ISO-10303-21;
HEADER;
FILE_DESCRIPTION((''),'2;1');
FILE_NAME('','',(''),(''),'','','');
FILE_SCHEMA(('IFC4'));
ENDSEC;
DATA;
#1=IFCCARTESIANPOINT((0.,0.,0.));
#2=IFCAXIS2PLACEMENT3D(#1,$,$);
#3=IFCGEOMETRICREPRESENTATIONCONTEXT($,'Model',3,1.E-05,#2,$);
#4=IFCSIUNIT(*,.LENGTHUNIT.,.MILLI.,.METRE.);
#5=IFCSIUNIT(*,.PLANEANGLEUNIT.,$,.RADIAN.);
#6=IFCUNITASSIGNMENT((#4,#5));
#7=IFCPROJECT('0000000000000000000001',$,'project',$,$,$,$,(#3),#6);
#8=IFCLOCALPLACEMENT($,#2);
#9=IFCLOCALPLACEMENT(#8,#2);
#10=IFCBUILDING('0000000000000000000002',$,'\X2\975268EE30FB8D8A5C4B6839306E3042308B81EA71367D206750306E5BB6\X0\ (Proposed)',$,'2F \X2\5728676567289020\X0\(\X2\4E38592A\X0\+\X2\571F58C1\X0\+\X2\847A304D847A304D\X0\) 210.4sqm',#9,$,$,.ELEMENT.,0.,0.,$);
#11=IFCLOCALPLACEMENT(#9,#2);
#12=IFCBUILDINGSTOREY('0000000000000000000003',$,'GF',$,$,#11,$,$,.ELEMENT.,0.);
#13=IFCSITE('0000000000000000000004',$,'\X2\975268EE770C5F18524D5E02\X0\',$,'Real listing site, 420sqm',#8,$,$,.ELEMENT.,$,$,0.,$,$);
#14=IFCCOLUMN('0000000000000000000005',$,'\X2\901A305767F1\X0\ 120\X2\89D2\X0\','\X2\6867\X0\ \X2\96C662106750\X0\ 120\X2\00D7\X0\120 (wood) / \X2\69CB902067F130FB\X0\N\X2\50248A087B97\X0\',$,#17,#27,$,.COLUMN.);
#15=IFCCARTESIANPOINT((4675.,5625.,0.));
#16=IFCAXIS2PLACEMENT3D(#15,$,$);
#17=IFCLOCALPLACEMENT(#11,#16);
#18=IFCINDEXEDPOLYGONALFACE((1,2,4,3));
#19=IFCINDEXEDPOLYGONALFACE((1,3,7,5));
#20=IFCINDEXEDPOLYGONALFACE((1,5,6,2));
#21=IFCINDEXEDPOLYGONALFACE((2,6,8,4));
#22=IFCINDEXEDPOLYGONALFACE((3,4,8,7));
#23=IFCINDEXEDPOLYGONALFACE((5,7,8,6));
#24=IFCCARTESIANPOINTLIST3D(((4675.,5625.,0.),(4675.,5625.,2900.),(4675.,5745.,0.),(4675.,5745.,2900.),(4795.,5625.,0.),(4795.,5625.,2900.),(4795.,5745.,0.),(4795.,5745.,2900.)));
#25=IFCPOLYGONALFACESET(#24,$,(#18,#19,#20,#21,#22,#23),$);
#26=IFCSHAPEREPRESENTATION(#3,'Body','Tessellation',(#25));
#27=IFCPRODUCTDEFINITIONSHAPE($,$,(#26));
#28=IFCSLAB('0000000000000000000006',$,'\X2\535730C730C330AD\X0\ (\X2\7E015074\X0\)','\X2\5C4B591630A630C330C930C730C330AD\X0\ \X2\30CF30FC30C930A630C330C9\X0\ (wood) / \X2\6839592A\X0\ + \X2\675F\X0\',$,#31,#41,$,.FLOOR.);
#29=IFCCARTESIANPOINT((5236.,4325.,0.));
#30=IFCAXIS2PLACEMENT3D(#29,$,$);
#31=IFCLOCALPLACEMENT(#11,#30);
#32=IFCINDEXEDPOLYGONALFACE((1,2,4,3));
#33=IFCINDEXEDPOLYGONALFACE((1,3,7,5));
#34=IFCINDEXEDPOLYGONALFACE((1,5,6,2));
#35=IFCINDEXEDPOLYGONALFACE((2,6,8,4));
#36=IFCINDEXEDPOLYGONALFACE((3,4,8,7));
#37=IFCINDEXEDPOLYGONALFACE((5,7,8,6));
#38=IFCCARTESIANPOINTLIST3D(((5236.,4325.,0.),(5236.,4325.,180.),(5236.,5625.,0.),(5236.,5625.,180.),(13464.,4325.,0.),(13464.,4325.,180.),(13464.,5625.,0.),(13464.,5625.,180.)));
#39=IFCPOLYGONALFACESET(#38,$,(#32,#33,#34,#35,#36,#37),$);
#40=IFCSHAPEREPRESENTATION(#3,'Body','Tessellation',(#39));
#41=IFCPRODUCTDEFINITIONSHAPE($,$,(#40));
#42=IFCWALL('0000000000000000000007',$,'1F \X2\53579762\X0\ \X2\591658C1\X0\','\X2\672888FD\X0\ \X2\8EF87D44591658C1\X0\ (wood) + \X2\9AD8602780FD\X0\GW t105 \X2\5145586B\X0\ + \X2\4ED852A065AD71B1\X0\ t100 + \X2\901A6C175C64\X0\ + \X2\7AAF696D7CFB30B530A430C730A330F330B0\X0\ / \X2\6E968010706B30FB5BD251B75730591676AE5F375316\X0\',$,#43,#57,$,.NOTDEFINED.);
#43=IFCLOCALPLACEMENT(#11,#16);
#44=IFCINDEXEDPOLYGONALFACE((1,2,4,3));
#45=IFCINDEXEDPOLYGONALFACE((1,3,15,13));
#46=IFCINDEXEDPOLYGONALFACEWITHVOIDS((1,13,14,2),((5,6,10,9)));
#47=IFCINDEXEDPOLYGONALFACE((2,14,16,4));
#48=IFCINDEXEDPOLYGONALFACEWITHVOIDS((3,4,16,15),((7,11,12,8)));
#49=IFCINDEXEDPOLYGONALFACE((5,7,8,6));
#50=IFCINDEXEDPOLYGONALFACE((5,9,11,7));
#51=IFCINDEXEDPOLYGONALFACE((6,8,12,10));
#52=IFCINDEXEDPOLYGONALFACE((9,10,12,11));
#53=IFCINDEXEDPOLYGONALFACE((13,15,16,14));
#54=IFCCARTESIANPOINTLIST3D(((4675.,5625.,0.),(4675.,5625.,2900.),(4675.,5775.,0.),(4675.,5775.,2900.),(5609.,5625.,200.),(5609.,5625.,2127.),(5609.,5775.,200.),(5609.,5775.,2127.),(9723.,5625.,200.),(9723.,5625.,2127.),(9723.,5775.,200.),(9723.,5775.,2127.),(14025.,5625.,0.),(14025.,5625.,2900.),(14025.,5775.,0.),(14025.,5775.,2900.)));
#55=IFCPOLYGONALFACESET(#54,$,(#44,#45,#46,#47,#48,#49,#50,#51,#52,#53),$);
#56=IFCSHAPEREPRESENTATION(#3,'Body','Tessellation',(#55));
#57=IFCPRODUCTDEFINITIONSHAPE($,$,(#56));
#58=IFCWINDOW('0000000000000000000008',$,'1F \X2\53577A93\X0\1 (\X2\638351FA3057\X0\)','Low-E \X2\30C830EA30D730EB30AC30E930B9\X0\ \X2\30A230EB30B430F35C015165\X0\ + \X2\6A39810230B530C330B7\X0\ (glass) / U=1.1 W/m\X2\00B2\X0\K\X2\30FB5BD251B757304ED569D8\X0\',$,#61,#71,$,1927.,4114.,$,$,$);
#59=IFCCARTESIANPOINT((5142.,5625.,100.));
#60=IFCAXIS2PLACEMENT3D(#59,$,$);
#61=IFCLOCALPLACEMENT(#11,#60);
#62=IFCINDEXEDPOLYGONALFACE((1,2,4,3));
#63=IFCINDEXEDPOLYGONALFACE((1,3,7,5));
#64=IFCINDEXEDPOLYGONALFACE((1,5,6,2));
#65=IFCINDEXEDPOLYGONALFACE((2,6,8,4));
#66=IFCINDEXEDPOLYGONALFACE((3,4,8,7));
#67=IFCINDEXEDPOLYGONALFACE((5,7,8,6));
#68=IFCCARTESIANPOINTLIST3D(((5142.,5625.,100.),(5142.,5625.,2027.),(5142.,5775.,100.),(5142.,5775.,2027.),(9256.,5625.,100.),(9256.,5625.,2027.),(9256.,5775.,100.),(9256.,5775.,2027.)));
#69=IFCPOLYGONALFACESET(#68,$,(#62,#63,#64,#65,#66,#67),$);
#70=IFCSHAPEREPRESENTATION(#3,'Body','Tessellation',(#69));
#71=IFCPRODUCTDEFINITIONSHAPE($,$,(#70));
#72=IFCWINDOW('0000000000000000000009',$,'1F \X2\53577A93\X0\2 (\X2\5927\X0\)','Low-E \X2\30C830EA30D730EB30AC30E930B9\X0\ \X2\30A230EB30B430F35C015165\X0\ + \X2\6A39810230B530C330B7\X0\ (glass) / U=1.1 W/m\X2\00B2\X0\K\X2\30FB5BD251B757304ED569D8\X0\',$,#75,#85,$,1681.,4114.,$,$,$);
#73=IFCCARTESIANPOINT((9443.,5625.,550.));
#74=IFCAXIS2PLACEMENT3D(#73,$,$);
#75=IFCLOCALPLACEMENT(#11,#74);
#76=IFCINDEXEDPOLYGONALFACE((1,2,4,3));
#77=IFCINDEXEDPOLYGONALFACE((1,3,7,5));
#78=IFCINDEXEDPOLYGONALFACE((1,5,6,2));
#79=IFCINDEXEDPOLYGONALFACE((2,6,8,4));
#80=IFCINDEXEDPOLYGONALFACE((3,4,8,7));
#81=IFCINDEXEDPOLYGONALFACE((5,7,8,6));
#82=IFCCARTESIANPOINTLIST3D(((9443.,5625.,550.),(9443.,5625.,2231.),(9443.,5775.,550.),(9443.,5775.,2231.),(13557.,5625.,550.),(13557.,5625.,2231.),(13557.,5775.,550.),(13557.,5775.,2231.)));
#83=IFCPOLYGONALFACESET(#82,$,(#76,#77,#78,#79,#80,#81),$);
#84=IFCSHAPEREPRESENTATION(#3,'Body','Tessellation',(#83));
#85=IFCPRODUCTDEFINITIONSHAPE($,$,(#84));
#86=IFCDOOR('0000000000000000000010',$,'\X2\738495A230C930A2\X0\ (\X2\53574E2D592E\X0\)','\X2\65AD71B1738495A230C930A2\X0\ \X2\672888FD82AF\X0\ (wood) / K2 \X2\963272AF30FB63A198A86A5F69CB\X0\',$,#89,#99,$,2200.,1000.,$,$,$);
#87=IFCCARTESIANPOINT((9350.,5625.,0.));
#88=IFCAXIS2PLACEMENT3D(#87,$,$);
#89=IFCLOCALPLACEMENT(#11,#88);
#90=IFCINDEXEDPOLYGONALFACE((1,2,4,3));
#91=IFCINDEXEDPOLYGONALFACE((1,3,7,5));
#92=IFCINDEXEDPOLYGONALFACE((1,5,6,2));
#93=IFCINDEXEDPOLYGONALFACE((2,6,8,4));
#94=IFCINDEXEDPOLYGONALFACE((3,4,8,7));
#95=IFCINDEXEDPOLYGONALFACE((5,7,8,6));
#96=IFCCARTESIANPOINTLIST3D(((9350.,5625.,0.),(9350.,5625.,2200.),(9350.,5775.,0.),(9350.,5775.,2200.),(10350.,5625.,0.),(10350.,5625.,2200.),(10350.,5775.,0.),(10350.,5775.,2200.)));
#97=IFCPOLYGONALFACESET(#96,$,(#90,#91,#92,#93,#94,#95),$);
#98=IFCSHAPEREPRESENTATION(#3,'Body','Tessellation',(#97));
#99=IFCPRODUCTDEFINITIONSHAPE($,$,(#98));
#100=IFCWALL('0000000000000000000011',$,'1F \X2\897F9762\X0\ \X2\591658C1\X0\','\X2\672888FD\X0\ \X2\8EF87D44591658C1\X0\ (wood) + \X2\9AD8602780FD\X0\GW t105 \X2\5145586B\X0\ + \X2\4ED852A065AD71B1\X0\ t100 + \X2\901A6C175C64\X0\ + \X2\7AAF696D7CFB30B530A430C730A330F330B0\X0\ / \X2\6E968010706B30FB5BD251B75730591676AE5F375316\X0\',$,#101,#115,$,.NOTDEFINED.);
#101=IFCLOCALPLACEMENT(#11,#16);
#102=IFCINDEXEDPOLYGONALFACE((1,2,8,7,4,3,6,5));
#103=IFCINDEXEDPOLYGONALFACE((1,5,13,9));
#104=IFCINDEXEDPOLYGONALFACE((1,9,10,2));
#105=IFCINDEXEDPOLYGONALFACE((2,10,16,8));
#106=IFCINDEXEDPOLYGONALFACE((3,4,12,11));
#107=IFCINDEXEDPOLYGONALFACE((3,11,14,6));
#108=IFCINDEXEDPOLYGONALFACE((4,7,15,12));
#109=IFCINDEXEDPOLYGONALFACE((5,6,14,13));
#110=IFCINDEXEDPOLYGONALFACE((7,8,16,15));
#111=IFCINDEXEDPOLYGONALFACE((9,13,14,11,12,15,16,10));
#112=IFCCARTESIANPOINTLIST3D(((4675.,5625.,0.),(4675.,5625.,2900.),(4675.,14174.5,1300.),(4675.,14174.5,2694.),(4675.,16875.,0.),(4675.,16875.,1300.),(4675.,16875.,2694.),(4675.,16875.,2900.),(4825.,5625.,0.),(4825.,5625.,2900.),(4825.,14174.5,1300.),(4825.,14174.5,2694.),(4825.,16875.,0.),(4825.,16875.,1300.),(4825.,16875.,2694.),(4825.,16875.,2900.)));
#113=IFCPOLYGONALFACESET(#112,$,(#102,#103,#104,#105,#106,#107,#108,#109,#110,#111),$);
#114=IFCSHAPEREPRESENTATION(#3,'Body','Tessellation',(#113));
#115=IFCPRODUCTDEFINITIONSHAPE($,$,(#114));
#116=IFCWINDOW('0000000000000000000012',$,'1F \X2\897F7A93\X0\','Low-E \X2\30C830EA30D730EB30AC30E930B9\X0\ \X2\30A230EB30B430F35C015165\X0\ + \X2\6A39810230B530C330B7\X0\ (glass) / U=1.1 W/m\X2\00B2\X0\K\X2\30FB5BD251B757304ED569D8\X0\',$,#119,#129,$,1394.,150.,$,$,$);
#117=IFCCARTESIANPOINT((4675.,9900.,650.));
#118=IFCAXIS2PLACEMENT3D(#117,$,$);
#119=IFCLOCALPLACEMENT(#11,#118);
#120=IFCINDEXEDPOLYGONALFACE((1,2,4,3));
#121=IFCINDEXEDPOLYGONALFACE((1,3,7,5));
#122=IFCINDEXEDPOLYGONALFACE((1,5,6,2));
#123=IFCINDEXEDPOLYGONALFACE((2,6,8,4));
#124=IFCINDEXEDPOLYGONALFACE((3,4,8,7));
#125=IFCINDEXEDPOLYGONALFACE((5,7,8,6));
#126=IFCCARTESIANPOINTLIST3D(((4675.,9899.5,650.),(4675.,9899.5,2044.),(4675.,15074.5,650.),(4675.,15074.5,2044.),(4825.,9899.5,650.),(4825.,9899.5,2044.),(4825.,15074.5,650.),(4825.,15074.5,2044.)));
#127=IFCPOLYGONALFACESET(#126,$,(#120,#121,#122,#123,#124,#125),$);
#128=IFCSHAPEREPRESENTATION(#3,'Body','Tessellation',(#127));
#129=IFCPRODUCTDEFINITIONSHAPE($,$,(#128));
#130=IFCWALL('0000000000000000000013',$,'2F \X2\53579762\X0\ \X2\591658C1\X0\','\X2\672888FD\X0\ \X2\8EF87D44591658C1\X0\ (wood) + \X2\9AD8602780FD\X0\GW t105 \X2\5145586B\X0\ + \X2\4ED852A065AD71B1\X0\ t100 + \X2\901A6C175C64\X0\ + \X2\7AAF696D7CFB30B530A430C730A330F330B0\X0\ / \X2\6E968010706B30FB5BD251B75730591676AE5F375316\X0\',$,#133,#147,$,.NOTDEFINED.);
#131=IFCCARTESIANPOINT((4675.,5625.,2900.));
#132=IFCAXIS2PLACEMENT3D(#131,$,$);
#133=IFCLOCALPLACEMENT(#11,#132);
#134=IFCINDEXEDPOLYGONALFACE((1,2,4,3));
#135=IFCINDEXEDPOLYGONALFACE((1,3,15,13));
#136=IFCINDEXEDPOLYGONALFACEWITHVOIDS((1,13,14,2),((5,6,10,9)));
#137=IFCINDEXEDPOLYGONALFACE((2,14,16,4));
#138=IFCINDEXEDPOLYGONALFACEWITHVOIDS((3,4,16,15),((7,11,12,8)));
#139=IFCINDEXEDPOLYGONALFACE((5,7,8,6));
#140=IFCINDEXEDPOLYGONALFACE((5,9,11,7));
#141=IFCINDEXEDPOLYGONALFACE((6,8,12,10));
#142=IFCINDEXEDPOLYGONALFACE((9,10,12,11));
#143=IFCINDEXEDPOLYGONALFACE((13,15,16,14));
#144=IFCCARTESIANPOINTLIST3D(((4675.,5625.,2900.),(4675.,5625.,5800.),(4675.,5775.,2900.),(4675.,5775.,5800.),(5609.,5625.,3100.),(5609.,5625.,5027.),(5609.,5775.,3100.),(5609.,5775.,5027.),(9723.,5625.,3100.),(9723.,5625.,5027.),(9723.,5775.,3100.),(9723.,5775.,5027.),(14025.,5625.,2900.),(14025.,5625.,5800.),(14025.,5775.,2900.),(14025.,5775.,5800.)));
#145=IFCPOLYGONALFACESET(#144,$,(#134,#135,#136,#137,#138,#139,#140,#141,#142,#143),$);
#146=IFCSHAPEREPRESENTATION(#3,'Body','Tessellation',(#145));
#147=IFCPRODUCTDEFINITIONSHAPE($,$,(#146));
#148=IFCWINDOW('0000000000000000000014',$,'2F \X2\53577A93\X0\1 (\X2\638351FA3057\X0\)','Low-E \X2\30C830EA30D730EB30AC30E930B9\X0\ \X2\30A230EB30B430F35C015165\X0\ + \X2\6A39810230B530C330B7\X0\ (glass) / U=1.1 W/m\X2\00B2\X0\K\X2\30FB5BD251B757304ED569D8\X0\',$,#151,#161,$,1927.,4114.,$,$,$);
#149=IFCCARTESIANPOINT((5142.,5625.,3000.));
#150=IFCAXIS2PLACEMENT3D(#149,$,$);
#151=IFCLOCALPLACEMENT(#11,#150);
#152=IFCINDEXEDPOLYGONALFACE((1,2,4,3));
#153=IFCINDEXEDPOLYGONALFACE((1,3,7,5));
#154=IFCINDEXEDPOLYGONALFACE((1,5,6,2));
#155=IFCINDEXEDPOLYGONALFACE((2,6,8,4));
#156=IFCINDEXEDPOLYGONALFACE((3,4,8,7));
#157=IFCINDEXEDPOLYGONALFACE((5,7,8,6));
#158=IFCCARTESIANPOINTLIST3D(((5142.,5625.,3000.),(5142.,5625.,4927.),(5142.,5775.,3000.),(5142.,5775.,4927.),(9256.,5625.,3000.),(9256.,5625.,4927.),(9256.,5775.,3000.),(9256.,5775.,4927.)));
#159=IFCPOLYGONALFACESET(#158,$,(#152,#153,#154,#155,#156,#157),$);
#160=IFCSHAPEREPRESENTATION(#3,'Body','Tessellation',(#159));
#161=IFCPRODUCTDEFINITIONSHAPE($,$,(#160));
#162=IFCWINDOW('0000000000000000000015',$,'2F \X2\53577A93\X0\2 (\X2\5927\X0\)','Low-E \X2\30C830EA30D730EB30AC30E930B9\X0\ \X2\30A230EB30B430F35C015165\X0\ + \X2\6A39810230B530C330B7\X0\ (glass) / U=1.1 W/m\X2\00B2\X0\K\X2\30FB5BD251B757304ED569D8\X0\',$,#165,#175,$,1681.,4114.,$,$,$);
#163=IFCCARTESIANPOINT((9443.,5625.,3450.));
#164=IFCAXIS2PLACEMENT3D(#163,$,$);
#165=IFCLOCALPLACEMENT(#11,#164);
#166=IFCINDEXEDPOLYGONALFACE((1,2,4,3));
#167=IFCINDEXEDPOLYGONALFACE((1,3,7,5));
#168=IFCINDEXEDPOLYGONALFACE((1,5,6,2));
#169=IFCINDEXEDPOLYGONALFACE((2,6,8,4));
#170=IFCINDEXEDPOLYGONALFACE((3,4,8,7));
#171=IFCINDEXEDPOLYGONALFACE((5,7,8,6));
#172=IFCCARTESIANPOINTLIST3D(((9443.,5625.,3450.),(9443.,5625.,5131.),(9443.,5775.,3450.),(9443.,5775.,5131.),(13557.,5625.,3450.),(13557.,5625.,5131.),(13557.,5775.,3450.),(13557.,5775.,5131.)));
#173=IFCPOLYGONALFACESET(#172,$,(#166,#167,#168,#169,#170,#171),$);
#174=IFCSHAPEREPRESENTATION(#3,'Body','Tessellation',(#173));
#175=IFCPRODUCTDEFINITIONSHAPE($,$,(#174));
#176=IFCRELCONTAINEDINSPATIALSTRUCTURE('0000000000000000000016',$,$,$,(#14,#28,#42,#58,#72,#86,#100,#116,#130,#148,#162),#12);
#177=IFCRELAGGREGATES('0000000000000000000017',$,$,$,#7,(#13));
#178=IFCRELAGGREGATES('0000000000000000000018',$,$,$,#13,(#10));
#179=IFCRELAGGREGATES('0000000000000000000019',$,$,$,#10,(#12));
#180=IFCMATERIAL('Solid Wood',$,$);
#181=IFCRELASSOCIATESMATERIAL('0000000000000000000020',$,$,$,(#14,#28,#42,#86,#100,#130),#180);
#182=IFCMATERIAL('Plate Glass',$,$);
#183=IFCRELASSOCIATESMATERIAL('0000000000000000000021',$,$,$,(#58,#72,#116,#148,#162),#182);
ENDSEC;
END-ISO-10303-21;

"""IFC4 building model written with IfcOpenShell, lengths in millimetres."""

from ifc_helpers import new_model, si_unit, frame, frame_2d, origin, place, context, project, spatial, rectangle, extrude, material, element, fill, save


model = new_model("IFC4")

# Units and contexts
model_context = context("Model", 3, precision=1e-05, world=origin())
ifc_project = project(units=[si_unit("LENGTHUNIT", "METRE", prefix="MILLI"), si_unit("PLANEANGLEUNIT", "RADIAN")], contexts=[model_context])

# Site, building, storey
site_placement = place(None, origin())
site = spatial("IfcSite", under=ifc_project, at=site_placement, Name="青森県弘前市", ObjectType="Real listing site, 420sqm", CompositionType="ELEMENT", RefElevation=0.0)
building_placement = place(site_placement, origin())
building = spatial("IfcBuilding", under=site, at=building_placement, Name="青森・越屋根のある自然素材の家 (Proposed)", ObjectType="2F 在来木造(丸太+土壁+葺き葺き) 210.4sqm", CompositionType="ELEMENT", ElevationOfRefHeight=0.0, ElevationOfTerrain=0.0)
storey_placement = place(building_placement, origin())
storey = spatial("IfcBuildingStorey", under=building, at=storey_placement, Name="GF", CompositionType="ELEMENT", Elevation=0.0)

# Column
ifc_material_1 = material(Name="Solid Wood")
column_placement = place(storey_placement, frame((4675.0, 5625.0, 0.0)))
element("IfcColumn", 1, at=column_placement, inside=storey, material=ifc_material_1, Name="通し柱 120角", Description="桧 集成材 120×120 (wood) / 構造柱・N値計算", PredefinedType="COLUMN", context=model_context, shape_type="SweptSolid", body=[
    extrude(rectangle(XDim=120.0, YDim=120.0, at=frame_2d((60.0, 60.0))), frame((4675.0, 5625.0, 0.0)), (0.0, 0.0, 1.0), 2900.0),
])

# Slab
slab_1_placement = place(storey_placement, frame((5236.0, 4325.0, 0.0)))
element("IfcSlab", 2, at=slab_1_placement, inside=storey, material=ifc_material_1, Name="南デッキ (縁側)", Description="屋外ウッドデッキ ハードウッド (wood) / 根太 + 束", PredefinedType="FLOOR", context=model_context, shape_type="SweptSolid", body=[
    extrude(rectangle(XDim=8228.0, YDim=1300.0, at=frame_2d((4114.0, 650.0))), frame((5236.0, 4325.0, 0.0)), (0.0, 0.0, 1.0), 180.0),
])

# Wall, openings, windows, door
wall_1_placement = place(storey_placement, frame((4675.0, 5625.0, 0.0)))
wall_1 = element("IfcWall", 3, at=wall_1_placement, inside=storey, material=ifc_material_1, Name="1F 南面 外壁", Description="木製 軸組外壁 (wood) + 高性能GW t105 充填 + 付加断熱 t100 + 通気層 + 窯業系サイディング / 準耐火・寒冷地外皮強化", PredefinedType="NOTDEFINED", context=model_context, shape_type="SweptSolid", body=[
    extrude(rectangle(XDim=9350.0, YDim=150.0, at=frame_2d((4675.0, 75.0))), frame((4675.0, 5625.0, 0.0)), (0.0, 0.0, 1.0), 2900.0),
])
opening_1_placement = place(storey_placement, frame((5142.0, 5625.0, 100.0)))
opening_1 = element("IfcOpeningElement", 4, at=opening_1_placement, cuts=wall_1, PredefinedType="NOTDEFINED", context=model_context, shape_type="SweptSolid", body=[
    extrude(rectangle(XDim=4114.0, YDim=150.0, at=frame_2d((2057.0, 75.0))), frame((5142.0, 5625.0, 100.0)), (0.0, 0.0, 1.0), 1927.0),
])
opening_2_placement = place(storey_placement, frame((9443.0, 5625.0, 550.0)))
opening_2 = element("IfcOpeningElement", 5, at=opening_2_placement, cuts=wall_1, PredefinedType="NOTDEFINED", context=model_context, shape_type="SweptSolid", body=[
    extrude(rectangle(XDim=4114.0, YDim=150.0, at=frame_2d((2057.0, 75.0))), frame((9443.0, 5625.0, 550.0)), (0.0, 0.0, 1.0), 1681.0),
])
opening_3_placement = place(storey_placement, frame((9350.0, 5625.0, 0.0)))
opening_3 = element("IfcOpeningElement", 6, at=opening_3_placement, cuts=wall_1, PredefinedType="NOTDEFINED", context=model_context, shape_type="SweptSolid", body=[
    extrude(rectangle(XDim=1000.0, YDim=150.0, at=frame_2d((500.0, 75.0))), frame((9350.0, 5625.0, 0.0)), (0.0, 0.0, 1.0), 2200.0),
])
ifc_material_2 = material(Name="Plate Glass")
window_1_placement = place(storey_placement, frame((5142.0, 5625.0, 100.0)))
window_1 = element("IfcWindow", 7, at=window_1_placement, inside=storey, material=ifc_material_2, Name="1F 南窓1 (掃出し)", Description="Low-E トリプルガラス アルゴン封入 + 樹脂サッシ (glass) / U=1.1 W/m²K・寒冷地仕様", OverallHeight=1927.0, OverallWidth=4114.0, context=model_context, shape_type="SweptSolid", body=[
    extrude(rectangle(XDim=4114.0, YDim=150.0, at=frame_2d((2057.0, 75.0))), frame((5142.0, 5625.0, 100.0)), (0.0, 0.0, 1.0), 1927.0),
])
fill(opening_1, window_1)
window_2_placement = place(storey_placement, frame((9443.0, 5625.0, 550.0)))
window_2 = element("IfcWindow", 8, at=window_2_placement, inside=storey, material=ifc_material_2, Name="1F 南窓2 (大)", Description="Low-E トリプルガラス アルゴン封入 + 樹脂サッシ (glass) / U=1.1 W/m²K・寒冷地仕様", OverallHeight=1681.0, OverallWidth=4114.0, context=model_context, shape_type="SweptSolid", body=[
    extrude(rectangle(XDim=4114.0, YDim=150.0, at=frame_2d((2057.0, 75.0))), frame((9443.0, 5625.0, 550.0)), (0.0, 0.0, 1.0), 1681.0),
])
fill(opening_2, window_2)
door_placement = place(storey_placement, frame((9350.0, 5625.0, 0.0)))
door = element("IfcDoor", 9, at=door_placement, inside=storey, material=ifc_material_1, Name="玄関ドア (南中央)", Description="断熱玄関ドア 木製芯 (wood) / K2 防犯・採風機構", OverallHeight=2200.0, OverallWidth=1000.0, context=model_context, shape_type="SweptSolid", body=[
    extrude(rectangle(XDim=1000.0, YDim=150.0, at=frame_2d((500.0, 75.0))), frame((9350.0, 5625.0, 0.0)), (0.0, 0.0, 1.0), 2200.0),
])
fill(opening_3, door)

# Wall, opening, window
wall_2_placement = place(storey_placement, frame((4675.0, 5625.0, 0.0)))
wall_2 = element("IfcWall", 10, at=wall_2_placement, inside=storey, material=ifc_material_1, Name="1F 西面 外壁", Description="木製 軸組外壁 (wood) + 高性能GW t105 充填 + 付加断熱 t100 + 通気層 + 窯業系サイディング / 準耐火・寒冷地外皮強化", PredefinedType="NOTDEFINED", context=model_context, shape_type="SweptSolid", body=[
    extrude(rectangle(XDim=150.0, YDim=11250.0, at=frame_2d((75.0, 5625.0))), frame((4675.0, 5625.0, 0.0)), (0.0, 0.0, 1.0), 2900.0),
])
opening_4_placement = place(storey_placement, frame((4675.0, 9900.0, 650.0)))
opening_4 = element("IfcOpeningElement", 11, at=opening_4_placement, cuts=wall_2, PredefinedType="NOTDEFINED", context=model_context, shape_type="SweptSolid", body=[
    extrude(rectangle(XDim=150.0, YDim=5175.0, at=frame_2d((75.0, 2587.0))), frame((4675.0, 9900.0, 650.0)), (0.0, 0.0, 1.0), 1394.0),
])
window_3_placement = place(storey_placement, frame((4675.0, 9900.0, 650.0)))
window_3 = element("IfcWindow", 12, at=window_3_placement, inside=storey, material=ifc_material_2, Name="1F 西窓", Description="Low-E トリプルガラス アルゴン封入 + 樹脂サッシ (glass) / U=1.1 W/m²K・寒冷地仕様", OverallHeight=1394.0, OverallWidth=150.0, context=model_context, shape_type="SweptSolid", body=[
    extrude(rectangle(XDim=150.0, YDim=5175.0, at=frame_2d((75.0, 2587.0))), frame((4675.0, 9900.0, 650.0)), (0.0, 0.0, 1.0), 1394.0),
])
fill(opening_4, window_3)

# Wall, openings, windows
wall_3_placement = place(storey_placement, frame((4675.0, 5625.0, 2900.0)))
wall_3 = element("IfcWall", 13, at=wall_3_placement, inside=storey, material=ifc_material_1, Name="2F 南面 外壁", Description="木製 軸組外壁 (wood) + 高性能GW t105 充填 + 付加断熱 t100 + 通気層 + 窯業系サイディング / 準耐火・寒冷地外皮強化", PredefinedType="NOTDEFINED", context=model_context, shape_type="SweptSolid", body=[
    extrude(rectangle(XDim=9350.0, YDim=150.0, at=frame_2d((4675.0, 75.0))), frame((4675.0, 5625.0, 2900.0)), (0.0, 0.0, 1.0), 2900.0),
])
opening_5_placement = place(storey_placement, frame((5142.0, 5625.0, 3000.0)))
opening_5 = element("IfcOpeningElement", 14, at=opening_5_placement, cuts=wall_3, PredefinedType="NOTDEFINED", context=model_context, shape_type="SweptSolid", body=[
    extrude(rectangle(XDim=4114.0, YDim=150.0, at=frame_2d((2057.0, 75.0))), frame((5142.0, 5625.0, 3000.0)), (0.0, 0.0, 1.0), 1927.0),
])
opening_6_placement = place(storey_placement, frame((9443.0, 5625.0, 3450.0)))
opening_6 = element("IfcOpeningElement", 15, at=opening_6_placement, cuts=wall_3, PredefinedType="NOTDEFINED", context=model_context, shape_type="SweptSolid", body=[
    extrude(rectangle(XDim=4114.0, YDim=150.0, at=frame_2d((2057.0, 75.0))), frame((9443.0, 5625.0, 3450.0)), (0.0, 0.0, 1.0), 1681.0),
])
window_4_placement = place(storey_placement, frame((5142.0, 5625.0, 3000.0)))
window_4 = element("IfcWindow", 16, at=window_4_placement, inside=storey, material=ifc_material_2, Name="2F 南窓1 (掃出し)", Description="Low-E トリプルガラス アルゴン封入 + 樹脂サッシ (glass) / U=1.1 W/m²K・寒冷地仕様", OverallHeight=1927.0, OverallWidth=4114.0, context=model_context, shape_type="SweptSolid", body=[
    extrude(rectangle(XDim=4114.0, YDim=150.0, at=frame_2d((2057.0, 75.0))), frame((5142.0, 5625.0, 3000.0)), (0.0, 0.0, 1.0), 1927.0),
])
fill(opening_5, window_4)
window_5_placement = place(storey_placement, frame((9443.0, 5625.0, 3450.0)))
window_5 = element("IfcWindow", 17, at=window_5_placement, inside=storey, material=ifc_material_2, Name="2F 南窓2 (大)", Description="Low-E トリプルガラス アルゴン封入 + 樹脂サッシ (glass) / U=1.1 W/m²K・寒冷地仕様", OverallHeight=1681.0, OverallWidth=4114.0, context=model_context, shape_type="SweptSolid", body=[
    extrude(rectangle(XDim=4114.0, YDim=150.0, at=frame_2d((2057.0, 75.0))), frame((9443.0, 5625.0, 3450.0)), (0.0, 0.0, 1.0), 1681.0),
])
fill(opening_6, window_5)

save(model, "model.ifc")
